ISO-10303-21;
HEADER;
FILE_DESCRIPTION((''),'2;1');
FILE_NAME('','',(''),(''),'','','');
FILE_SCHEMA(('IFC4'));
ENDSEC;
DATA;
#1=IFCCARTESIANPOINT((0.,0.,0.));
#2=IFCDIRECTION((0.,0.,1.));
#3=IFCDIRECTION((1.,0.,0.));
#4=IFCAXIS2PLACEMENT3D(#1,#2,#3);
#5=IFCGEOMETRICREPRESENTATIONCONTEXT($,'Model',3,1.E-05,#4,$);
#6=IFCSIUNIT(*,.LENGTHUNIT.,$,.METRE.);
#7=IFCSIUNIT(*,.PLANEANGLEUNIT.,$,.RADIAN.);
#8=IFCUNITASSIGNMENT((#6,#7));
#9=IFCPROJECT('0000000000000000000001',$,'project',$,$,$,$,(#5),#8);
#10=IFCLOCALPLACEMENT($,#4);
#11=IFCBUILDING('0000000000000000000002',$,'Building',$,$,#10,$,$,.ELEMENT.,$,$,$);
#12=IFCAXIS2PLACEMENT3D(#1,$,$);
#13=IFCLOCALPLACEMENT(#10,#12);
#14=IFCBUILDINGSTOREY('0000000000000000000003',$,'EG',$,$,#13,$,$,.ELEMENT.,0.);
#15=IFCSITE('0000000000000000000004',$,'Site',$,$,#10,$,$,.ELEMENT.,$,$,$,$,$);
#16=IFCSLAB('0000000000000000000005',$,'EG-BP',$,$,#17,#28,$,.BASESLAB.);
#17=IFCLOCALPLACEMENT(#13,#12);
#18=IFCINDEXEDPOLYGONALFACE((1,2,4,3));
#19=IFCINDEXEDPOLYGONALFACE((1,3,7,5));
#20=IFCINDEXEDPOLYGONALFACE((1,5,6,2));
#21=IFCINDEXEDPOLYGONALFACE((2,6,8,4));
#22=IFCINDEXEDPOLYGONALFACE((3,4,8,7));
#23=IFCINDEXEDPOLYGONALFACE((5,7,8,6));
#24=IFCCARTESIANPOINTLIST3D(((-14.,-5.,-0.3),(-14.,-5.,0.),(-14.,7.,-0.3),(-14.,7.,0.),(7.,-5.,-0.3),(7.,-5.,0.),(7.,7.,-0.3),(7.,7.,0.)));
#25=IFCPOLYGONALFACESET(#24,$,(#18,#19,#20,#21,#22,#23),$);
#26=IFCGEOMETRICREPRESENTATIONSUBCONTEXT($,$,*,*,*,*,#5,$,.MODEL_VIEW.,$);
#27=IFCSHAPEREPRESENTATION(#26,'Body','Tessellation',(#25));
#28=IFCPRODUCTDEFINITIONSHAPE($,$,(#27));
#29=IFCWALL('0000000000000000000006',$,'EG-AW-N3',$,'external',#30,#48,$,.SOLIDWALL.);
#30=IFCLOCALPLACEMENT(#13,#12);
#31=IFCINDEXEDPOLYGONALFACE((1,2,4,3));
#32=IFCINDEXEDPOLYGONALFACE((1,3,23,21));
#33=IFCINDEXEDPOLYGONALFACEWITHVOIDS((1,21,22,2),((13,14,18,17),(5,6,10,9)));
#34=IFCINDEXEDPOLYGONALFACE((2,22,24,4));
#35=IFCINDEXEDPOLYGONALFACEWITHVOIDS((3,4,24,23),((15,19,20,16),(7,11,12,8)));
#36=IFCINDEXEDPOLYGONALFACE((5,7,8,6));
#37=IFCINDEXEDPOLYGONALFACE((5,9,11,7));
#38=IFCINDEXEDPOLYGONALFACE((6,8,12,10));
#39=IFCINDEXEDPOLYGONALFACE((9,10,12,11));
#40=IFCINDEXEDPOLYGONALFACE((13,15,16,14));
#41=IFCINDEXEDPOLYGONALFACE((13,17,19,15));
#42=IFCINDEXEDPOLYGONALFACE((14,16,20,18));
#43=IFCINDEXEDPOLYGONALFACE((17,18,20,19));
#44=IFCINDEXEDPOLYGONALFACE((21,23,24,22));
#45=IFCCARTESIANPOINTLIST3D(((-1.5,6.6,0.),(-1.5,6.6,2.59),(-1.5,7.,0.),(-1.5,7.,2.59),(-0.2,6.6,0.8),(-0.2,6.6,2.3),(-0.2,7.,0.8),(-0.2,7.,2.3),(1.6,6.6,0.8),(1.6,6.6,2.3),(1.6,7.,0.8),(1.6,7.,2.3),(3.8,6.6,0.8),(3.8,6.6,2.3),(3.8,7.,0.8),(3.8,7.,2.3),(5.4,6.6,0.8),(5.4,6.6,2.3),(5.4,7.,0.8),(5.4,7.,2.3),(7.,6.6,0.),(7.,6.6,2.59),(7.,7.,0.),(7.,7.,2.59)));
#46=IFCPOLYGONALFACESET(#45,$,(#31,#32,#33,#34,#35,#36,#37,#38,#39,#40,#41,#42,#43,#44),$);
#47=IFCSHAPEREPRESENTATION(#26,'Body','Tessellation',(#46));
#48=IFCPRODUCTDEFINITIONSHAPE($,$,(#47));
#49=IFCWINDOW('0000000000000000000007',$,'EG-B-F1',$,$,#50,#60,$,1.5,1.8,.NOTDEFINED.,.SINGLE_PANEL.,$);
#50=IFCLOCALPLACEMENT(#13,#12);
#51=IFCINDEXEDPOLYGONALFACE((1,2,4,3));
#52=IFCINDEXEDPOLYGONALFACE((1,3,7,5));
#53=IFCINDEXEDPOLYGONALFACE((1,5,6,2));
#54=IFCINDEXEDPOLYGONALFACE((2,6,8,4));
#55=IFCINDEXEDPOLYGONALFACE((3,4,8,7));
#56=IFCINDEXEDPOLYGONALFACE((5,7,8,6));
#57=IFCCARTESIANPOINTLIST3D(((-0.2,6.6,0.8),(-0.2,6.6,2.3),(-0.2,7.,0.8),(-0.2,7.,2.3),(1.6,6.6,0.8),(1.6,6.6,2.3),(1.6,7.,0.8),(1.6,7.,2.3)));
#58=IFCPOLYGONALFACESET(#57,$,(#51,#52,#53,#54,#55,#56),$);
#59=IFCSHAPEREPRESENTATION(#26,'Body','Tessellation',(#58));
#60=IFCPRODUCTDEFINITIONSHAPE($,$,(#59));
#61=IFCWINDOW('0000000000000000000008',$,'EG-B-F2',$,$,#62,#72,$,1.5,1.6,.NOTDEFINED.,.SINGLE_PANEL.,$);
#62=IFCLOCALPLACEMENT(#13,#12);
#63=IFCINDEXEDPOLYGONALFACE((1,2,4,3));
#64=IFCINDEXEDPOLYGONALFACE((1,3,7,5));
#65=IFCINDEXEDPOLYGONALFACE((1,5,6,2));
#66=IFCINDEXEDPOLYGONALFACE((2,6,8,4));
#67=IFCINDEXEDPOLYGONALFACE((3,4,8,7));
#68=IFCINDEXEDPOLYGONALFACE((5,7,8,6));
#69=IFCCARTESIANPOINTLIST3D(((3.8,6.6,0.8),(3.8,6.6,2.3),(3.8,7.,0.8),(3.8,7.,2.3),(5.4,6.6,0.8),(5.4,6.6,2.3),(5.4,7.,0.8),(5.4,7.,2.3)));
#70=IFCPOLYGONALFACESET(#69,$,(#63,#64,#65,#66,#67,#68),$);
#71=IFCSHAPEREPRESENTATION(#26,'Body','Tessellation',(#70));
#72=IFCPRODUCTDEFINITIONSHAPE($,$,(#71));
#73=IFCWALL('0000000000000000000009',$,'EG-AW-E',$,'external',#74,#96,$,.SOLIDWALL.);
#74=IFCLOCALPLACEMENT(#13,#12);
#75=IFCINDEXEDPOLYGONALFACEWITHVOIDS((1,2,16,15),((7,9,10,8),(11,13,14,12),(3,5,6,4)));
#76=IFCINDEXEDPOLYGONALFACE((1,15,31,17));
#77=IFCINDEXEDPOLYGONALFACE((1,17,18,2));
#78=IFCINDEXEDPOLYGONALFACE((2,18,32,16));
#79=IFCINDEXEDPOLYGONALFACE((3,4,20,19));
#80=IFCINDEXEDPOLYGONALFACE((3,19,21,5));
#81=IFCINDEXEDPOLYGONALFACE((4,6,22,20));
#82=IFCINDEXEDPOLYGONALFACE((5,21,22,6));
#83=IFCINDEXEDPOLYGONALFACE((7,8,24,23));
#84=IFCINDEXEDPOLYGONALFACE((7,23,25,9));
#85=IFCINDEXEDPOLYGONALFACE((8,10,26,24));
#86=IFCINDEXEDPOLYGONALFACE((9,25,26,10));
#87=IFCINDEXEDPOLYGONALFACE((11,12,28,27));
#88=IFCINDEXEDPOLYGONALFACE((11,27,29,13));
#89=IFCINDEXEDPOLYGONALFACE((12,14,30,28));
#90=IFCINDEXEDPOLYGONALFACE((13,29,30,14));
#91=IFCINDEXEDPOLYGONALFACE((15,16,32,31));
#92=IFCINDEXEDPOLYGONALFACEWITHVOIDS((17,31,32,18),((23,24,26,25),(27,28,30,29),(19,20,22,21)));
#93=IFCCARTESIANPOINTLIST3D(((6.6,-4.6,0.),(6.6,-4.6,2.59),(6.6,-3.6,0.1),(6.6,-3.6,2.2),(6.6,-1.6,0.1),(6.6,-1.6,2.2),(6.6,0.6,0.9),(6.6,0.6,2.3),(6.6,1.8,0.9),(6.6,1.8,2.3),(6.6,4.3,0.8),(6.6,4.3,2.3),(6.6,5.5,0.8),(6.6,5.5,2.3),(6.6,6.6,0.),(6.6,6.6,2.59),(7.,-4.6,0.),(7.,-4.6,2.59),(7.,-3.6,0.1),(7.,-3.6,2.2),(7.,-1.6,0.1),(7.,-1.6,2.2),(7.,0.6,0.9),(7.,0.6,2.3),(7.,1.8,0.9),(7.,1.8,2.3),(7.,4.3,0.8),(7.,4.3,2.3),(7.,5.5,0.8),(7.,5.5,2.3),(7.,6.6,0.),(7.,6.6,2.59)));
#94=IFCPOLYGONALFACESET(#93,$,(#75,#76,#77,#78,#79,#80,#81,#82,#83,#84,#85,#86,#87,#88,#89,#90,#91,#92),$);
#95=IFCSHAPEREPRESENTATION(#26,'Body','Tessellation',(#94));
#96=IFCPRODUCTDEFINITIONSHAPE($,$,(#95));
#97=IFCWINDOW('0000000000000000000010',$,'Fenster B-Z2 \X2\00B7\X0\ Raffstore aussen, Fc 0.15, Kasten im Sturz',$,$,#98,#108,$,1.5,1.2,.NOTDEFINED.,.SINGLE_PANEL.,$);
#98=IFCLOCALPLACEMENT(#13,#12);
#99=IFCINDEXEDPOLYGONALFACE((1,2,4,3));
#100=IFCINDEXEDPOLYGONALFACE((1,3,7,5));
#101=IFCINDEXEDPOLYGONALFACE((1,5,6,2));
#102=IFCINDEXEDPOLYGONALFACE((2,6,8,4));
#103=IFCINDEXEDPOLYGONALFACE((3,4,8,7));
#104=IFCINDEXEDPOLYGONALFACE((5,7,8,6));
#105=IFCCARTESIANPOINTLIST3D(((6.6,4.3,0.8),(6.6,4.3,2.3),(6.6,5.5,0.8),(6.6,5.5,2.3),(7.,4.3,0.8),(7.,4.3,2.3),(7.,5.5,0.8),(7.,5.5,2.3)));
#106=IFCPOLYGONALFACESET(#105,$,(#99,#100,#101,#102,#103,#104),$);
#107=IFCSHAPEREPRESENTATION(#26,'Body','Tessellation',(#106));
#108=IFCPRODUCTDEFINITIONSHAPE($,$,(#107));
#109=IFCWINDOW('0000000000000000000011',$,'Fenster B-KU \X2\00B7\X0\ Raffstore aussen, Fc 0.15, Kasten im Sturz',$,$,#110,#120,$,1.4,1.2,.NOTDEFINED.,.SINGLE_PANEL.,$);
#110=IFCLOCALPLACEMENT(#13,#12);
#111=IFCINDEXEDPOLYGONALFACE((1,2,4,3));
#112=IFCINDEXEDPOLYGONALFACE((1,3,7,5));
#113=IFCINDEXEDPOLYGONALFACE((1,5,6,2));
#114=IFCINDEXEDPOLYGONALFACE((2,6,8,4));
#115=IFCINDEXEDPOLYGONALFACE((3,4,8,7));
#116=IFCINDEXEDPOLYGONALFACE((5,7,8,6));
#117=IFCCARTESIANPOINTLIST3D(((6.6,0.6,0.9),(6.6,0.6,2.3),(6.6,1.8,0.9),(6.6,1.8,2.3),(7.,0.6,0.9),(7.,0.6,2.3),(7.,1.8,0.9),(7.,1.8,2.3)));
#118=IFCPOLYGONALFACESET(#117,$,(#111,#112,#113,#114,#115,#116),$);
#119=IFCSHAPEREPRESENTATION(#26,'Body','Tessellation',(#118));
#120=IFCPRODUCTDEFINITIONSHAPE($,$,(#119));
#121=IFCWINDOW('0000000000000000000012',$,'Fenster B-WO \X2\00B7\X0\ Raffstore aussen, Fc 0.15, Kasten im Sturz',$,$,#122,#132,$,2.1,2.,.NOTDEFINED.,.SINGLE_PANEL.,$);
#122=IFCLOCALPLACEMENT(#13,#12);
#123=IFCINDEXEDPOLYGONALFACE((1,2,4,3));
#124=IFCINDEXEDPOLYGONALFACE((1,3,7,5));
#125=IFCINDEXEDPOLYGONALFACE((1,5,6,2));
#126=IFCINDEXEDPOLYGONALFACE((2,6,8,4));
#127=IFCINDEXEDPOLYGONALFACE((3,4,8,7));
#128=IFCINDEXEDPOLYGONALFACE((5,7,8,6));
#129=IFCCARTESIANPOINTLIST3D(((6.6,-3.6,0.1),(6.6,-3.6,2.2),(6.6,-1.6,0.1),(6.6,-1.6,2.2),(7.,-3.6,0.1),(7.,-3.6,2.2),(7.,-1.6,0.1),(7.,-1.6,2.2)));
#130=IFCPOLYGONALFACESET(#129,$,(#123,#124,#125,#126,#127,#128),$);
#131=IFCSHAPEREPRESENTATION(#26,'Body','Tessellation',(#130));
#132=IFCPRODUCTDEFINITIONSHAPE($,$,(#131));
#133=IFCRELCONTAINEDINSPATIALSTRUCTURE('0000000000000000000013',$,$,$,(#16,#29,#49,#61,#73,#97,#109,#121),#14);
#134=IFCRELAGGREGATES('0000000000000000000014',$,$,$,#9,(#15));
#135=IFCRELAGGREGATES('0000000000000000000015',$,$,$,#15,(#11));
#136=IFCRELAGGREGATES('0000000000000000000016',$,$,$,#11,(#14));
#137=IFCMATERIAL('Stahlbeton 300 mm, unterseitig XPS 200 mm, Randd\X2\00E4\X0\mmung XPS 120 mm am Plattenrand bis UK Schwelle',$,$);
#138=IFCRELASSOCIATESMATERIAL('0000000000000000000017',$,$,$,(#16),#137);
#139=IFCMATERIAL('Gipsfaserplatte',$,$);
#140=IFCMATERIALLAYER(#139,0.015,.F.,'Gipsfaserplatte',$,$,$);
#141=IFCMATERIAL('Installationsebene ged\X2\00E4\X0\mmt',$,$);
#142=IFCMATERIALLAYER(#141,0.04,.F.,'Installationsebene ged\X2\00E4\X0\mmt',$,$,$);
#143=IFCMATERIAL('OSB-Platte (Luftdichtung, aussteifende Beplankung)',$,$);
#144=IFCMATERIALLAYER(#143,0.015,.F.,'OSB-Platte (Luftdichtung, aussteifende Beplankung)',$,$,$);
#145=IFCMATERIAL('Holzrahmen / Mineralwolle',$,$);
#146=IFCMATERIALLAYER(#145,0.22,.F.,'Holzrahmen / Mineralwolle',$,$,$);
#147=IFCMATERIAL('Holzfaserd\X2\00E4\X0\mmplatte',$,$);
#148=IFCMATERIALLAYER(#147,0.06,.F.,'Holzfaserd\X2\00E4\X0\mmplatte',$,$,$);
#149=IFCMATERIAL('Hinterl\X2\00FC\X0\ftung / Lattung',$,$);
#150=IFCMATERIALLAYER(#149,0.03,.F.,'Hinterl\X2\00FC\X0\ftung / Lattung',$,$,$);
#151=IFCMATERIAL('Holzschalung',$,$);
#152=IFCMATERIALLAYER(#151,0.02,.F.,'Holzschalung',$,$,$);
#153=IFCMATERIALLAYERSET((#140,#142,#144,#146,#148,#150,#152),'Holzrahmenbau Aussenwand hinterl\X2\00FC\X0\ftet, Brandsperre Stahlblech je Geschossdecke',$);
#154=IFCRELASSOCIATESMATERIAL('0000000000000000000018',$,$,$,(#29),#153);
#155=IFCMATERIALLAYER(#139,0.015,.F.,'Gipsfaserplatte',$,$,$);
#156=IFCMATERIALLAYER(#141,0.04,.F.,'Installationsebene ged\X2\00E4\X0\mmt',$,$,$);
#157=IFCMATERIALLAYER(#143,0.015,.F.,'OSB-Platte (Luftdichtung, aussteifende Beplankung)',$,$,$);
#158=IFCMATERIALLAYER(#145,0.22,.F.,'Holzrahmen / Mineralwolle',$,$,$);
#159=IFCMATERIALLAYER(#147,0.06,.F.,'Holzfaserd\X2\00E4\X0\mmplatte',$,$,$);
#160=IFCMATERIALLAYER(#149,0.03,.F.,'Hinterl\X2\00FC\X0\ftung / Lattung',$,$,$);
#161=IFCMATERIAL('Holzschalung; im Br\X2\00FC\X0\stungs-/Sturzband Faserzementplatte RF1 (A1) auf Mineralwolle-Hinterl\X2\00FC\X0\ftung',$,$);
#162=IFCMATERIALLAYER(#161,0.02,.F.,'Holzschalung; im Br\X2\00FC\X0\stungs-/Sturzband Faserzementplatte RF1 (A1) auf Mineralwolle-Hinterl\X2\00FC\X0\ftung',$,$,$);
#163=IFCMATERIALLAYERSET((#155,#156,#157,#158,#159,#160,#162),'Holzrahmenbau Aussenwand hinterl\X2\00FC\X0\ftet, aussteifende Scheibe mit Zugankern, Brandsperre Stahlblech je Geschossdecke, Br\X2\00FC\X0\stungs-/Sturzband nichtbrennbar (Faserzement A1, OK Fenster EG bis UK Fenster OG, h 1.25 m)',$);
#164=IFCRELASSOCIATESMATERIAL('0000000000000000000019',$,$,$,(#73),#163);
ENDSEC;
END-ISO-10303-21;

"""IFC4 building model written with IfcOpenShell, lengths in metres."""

from ifc_helpers import new_model, si_unit, frame, frame_2d, origin, origin_with_axes, place, context, subcontext, project, spatial, polyline, rectangle, outline, extrude, material, layer, layer_set, element, fill, save


model = new_model("IFC4")

# Units and contexts
model_context = context("Model", 3, precision=1e-05, world=origin_with_axes())
sub_context = subcontext(model_context, None, None, "MODEL_VIEW")
ifc_project = project(units=[si_unit("LENGTHUNIT", "METRE"), si_unit("PLANEANGLEUNIT", "RADIAN")], contexts=[model_context])

# Site, building, storey
placement = place(None, origin_with_axes())
site = spatial("IfcSite", under=ifc_project, at=placement, Name="Site", CompositionType="ELEMENT")
building = spatial("IfcBuilding", under=site, at=placement, Name="Building", CompositionType="ELEMENT")
storey_placement = place(placement, origin())
storey = spatial("IfcBuildingStorey", under=building, at=storey_placement, Name="EG", CompositionType="ELEMENT", Elevation=0.0)

# Slab
ifc_material_1 = material(Name="Stahlbeton 300 mm, unterseitig XPS 200 mm, Randdämmung XPS 120 mm am Plattenrand bis UK Schwelle")
slab_placement = place(storey_placement, frame((0.0, 0.0, -0.3)))
element("IfcSlab", 1, at=slab_placement, inside=storey, material=ifc_material_1, Name="EG-BP", PredefinedType="BASESLAB", context=sub_context, shape_type="SweptSolid", body=[
    extrude(outline(polyline([(-14.0, -5.0), (7.0, -5.0), (7.0, 7.0), (-14.0, 7.0), (-14.0, -5.0)])), origin(), (0.0, 0.0, 1.0), 0.3),
])

# Walls, openings, windows
ifc_material_2 = material(Name="Gipsfaserplatte")
ifc_layer_1 = layer(ifc_material_2, 0.015, ventilated=False, Name="Gipsfaserplatte")
ifc_material_3 = material(Name="Installationsebene gedämmt")
ifc_layer_2 = layer(ifc_material_3, 0.04, ventilated=False, Name="Installationsebene gedämmt")
ifc_material_4 = material(Name="OSB-Platte (Luftdichtung, aussteifende Beplankung)")
ifc_layer_3 = layer(ifc_material_4, 0.015, ventilated=False, Name="OSB-Platte (Luftdichtung, aussteifende Beplankung)")
ifc_material_5 = material(Name="Holzrahmen / Mineralwolle")
ifc_layer_4 = layer(ifc_material_5, 0.22, ventilated=False, Name="Holzrahmen / Mineralwolle")
ifc_material_6 = material(Name="Holzfaserdämmplatte")
ifc_layer_5 = layer(ifc_material_6, 0.06, ventilated=False, Name="Holzfaserdämmplatte")
ifc_material_7 = material(Name="Hinterlüftung / Lattung")
ifc_layer_6 = layer(ifc_material_7, 0.03, ventilated=False, Name="Hinterlüftung / Lattung")
ifc_material_8 = material(Name="Holzschalung")
ifc_layer_7 = layer(ifc_material_8, 0.02, ventilated=False, Name="Holzschalung")
ifc_layer_set_1 = layer_set([ifc_layer_1, ifc_layer_2, ifc_layer_3, ifc_layer_4, ifc_layer_5, ifc_layer_6, ifc_layer_7], Name="Holzrahmenbau Aussenwand hinterlüftet, Brandsperre Stahlblech je Geschossdecke")
wall_1_placement = place(storey_placement, frame((-1.5, 6.8, 0.0), z_axis=(0.0, 0.0, 1.0), x_axis=(1.0, 0.0, 0.0)))
wall_1 = element("IfcWall", 2, at=wall_1_placement, inside=storey, material=ifc_layer_set_1, Name="EG-AW-N3", ObjectType="external", PredefinedType="SOLIDWALL", context=sub_context, shape_type="SweptSolid", body=[
    extrude(rectangle(XDim=8.5, YDim=0.4, at=frame_2d((4.25, 0.0))), origin(), (0.0, 0.0, 1.0), 2.59),
])
opening_1_placement = place(wall_1_placement, frame((2.2, 0.25, 0.8), z_axis=(0.0, -1.0, 0.0), x_axis=(1.0, 0.0, 0.0)))
opening_1 = element("IfcOpeningElement", 3, at=opening_1_placement, cuts=wall_1, PredefinedType="OPENING", context=sub_context, shape_type="SweptSolid", body=[
    extrude(rectangle(XDim=1.8, YDim=1.5, at=frame_2d((0.0, 0.75))), origin(), (0.0, 0.0, 1.0), 0.5),
])
opening_2_placement = place(wall_1_placement, frame((6.1, 0.25, 0.8), z_axis=(0.0, -1.0, 0.0), x_axis=(1.0, 0.0, 0.0)))
opening_2 = element("IfcOpeningElement", 4, at=opening_2_placement, cuts=wall_1, PredefinedType="OPENING", context=sub_context, shape_type="SweptSolid", body=[
    extrude(rectangle(XDim=1.6, YDim=1.5, at=frame_2d((0.0, 0.75))), origin(), (0.0, 0.0, 1.0), 0.5),
])
window_1_placement = place(wall_1_placement, frame((2.2, 0.2, 0.8), z_axis=(0.0, -1.0, 0.0), x_axis=(1.0, 0.0, 0.0)))
window_1 = element("IfcWindow", 5, at=window_1_placement, inside=storey, Name="EG-B-F1", OverallHeight=1.5, OverallWidth=1.8, PartitioningType="SINGLE_PANEL", PredefinedType="NOTDEFINED", context=sub_context, shape_type="SweptSolid", body=[
    extrude(rectangle(XDim=1.8, YDim=1.5, at=frame_2d((0.0, 0.75))), origin(), (0.0, 0.0, 1.0), 0.4),
])
fill(opening_1, window_1)
window_2_placement = place(wall_1_placement, frame((6.1, 0.2, 0.8), z_axis=(0.0, -1.0, 0.0), x_axis=(1.0, 0.0, 0.0)))
window_2 = element("IfcWindow", 6, at=window_2_placement, inside=storey, Name="EG-B-F2", OverallHeight=1.5, OverallWidth=1.6, PartitioningType="SINGLE_PANEL", PredefinedType="NOTDEFINED", context=sub_context, shape_type="SweptSolid", body=[
    extrude(rectangle(XDim=1.6, YDim=1.5, at=frame_2d((0.0, 0.75))), origin(), (0.0, 0.0, 1.0), 0.4),
])
fill(opening_2, window_2)
ifc_layer_8 = layer(ifc_material_2, 0.015, ventilated=False, Name="Gipsfaserplatte")
ifc_layer_9 = layer(ifc_material_3, 0.04, ventilated=False, Name="Installationsebene gedämmt")
ifc_layer_10 = layer(ifc_material_4, 0.015, ventilated=False, Name="OSB-Platte (Luftdichtung, aussteifende Beplankung)")
ifc_layer_11 = layer(ifc_material_5, 0.22, ventilated=False, Name="Holzrahmen / Mineralwolle")
ifc_layer_12 = layer(ifc_material_6, 0.06, ventilated=False, Name="Holzfaserdämmplatte")
ifc_layer_13 = layer(ifc_material_7, 0.03, ventilated=False, Name="Hinterlüftung / Lattung")
ifc_material_9 = material(Name="Holzschalung; im Brüstungs-/Sturzband Faserzementplatte RF1 (A1) auf Mineralwolle-Hinterlüftung")
ifc_layer_14 = layer(ifc_material_9, 0.02, ventilated=False, Name="Holzschalung; im Brüstungs-/Sturzband Faserzementplatte RF1 (A1) auf Mineralwolle-Hinterlüftung")
ifc_layer_set_2 = layer_set([ifc_layer_8, ifc_layer_9, ifc_layer_10, ifc_layer_11, ifc_layer_12, ifc_layer_13, ifc_layer_14], Name="Holzrahmenbau Aussenwand hinterlüftet, aussteifende Scheibe mit Zugankern, Brandsperre Stahlblech je Geschossdecke, Brüstungs-/Sturzband nichtbrennbar (Faserzement A1, OK Fenster EG bis UK Fenster OG, h 1.25 m)")
wall_2_placement = place(storey_placement, frame((6.8, 6.6, 0.0), z_axis=(0.0, 0.0, 1.0), x_axis=(0.0, -1.0, 0.0)))
wall_2 = element("IfcWall", 7, at=wall_2_placement, inside=storey, material=ifc_layer_set_2, Name="EG-AW-E", ObjectType="external", PredefinedType="SOLIDWALL", context=sub_context, shape_type="SweptSolid", body=[
    extrude(rectangle(XDim=11.2, YDim=0.4, at=frame_2d((5.6, 0.0))), origin(), (0.0, 0.0, 1.0), 2.59),
])
opening_3_placement = place(wall_2_placement, frame((1.7, 0.25, 0.8), z_axis=(0.0, -1.0, 0.0), x_axis=(1.0, 0.0, 0.0)))
opening_3 = element("IfcOpeningElement", 8, at=opening_3_placement, cuts=wall_2, PredefinedType="OPENING", context=sub_context, shape_type="SweptSolid", body=[
    extrude(rectangle(XDim=1.2, YDim=1.5, at=frame_2d((0.0, 0.75))), origin(), (0.0, 0.0, 1.0), 0.5),
])
opening_4_placement = place(wall_2_placement, frame((5.4, 0.25, 0.9), z_axis=(0.0, -1.0, 0.0), x_axis=(1.0, 0.0, 0.0)))
opening_4 = element("IfcOpeningElement", 9, at=opening_4_placement, cuts=wall_2, PredefinedType="OPENING", context=sub_context, shape_type="SweptSolid", body=[
    extrude(rectangle(XDim=1.2, YDim=1.4, at=frame_2d((0.0, 0.7))), origin(), (0.0, 0.0, 1.0), 0.5),
])
opening_5_placement = place(wall_2_placement, frame((9.2, 0.25, 0.1), z_axis=(0.0, -1.0, 0.0), x_axis=(1.0, 0.0, 0.0)))
opening_5 = element("IfcOpeningElement", 10, at=opening_5_placement, cuts=wall_2, PredefinedType="OPENING", context=sub_context, shape_type="SweptSolid", body=[
    extrude(rectangle(XDim=2.0, YDim=2.1, at=frame_2d((0.0, 1.05))), origin(), (0.0, 0.0, 1.0), 0.5),
])
window_3_placement = place(wall_2_placement, frame((1.7, 0.2, 0.8), z_axis=(0.0, -1.0, 0.0), x_axis=(1.0, 0.0, 0.0)))
window_3 = element("IfcWindow", 11, at=window_3_placement, inside=storey, Name="Fenster B-Z2 · Raffstore aussen, Fc 0.15, Kasten im Sturz", OverallHeight=1.5, OverallWidth=1.2, PartitioningType="SINGLE_PANEL", PredefinedType="NOTDEFINED", context=sub_context, shape_type="SweptSolid", body=[
    extrude(rectangle(XDim=1.2, YDim=1.5, at=frame_2d((0.0, 0.75))), origin(), (0.0, 0.0, 1.0), 0.4),
])
fill(opening_3, window_3)
window_4_placement = place(wall_2_placement, frame((5.4, 0.2, 0.9), z_axis=(0.0, -1.0, 0.0), x_axis=(1.0, 0.0, 0.0)))
window_4 = element("IfcWindow", 12, at=window_4_placement, inside=storey, Name="Fenster B-KU · Raffstore aussen, Fc 0.15, Kasten im Sturz", OverallHeight=1.4, OverallWidth=1.2, PartitioningType="SINGLE_PANEL", PredefinedType="NOTDEFINED", context=sub_context, shape_type="SweptSolid", body=[
    extrude(rectangle(XDim=1.2, YDim=1.4, at=frame_2d((0.0, 0.7))), origin(), (0.0, 0.0, 1.0), 0.4),
])
fill(opening_4, window_4)
window_5_placement = place(wall_2_placement, frame((9.2, 0.2, 0.1), z_axis=(0.0, -1.0, 0.0), x_axis=(1.0, 0.0, 0.0)))
window_5 = element("IfcWindow", 13, at=window_5_placement, inside=storey, Name="Fenster B-WO · Raffstore aussen, Fc 0.15, Kasten im Sturz", OverallHeight=2.1, OverallWidth=2.0, PartitioningType="SINGLE_PANEL", PredefinedType="NOTDEFINED", context=sub_context, shape_type="SweptSolid", body=[
    extrude(rectangle(XDim=2.0, YDim=2.1, at=frame_2d((0.0, 1.05))), origin(), (0.0, 0.0, 1.0), 0.4),
])
fill(opening_5, window_5)

save(model, "model.ifc")
